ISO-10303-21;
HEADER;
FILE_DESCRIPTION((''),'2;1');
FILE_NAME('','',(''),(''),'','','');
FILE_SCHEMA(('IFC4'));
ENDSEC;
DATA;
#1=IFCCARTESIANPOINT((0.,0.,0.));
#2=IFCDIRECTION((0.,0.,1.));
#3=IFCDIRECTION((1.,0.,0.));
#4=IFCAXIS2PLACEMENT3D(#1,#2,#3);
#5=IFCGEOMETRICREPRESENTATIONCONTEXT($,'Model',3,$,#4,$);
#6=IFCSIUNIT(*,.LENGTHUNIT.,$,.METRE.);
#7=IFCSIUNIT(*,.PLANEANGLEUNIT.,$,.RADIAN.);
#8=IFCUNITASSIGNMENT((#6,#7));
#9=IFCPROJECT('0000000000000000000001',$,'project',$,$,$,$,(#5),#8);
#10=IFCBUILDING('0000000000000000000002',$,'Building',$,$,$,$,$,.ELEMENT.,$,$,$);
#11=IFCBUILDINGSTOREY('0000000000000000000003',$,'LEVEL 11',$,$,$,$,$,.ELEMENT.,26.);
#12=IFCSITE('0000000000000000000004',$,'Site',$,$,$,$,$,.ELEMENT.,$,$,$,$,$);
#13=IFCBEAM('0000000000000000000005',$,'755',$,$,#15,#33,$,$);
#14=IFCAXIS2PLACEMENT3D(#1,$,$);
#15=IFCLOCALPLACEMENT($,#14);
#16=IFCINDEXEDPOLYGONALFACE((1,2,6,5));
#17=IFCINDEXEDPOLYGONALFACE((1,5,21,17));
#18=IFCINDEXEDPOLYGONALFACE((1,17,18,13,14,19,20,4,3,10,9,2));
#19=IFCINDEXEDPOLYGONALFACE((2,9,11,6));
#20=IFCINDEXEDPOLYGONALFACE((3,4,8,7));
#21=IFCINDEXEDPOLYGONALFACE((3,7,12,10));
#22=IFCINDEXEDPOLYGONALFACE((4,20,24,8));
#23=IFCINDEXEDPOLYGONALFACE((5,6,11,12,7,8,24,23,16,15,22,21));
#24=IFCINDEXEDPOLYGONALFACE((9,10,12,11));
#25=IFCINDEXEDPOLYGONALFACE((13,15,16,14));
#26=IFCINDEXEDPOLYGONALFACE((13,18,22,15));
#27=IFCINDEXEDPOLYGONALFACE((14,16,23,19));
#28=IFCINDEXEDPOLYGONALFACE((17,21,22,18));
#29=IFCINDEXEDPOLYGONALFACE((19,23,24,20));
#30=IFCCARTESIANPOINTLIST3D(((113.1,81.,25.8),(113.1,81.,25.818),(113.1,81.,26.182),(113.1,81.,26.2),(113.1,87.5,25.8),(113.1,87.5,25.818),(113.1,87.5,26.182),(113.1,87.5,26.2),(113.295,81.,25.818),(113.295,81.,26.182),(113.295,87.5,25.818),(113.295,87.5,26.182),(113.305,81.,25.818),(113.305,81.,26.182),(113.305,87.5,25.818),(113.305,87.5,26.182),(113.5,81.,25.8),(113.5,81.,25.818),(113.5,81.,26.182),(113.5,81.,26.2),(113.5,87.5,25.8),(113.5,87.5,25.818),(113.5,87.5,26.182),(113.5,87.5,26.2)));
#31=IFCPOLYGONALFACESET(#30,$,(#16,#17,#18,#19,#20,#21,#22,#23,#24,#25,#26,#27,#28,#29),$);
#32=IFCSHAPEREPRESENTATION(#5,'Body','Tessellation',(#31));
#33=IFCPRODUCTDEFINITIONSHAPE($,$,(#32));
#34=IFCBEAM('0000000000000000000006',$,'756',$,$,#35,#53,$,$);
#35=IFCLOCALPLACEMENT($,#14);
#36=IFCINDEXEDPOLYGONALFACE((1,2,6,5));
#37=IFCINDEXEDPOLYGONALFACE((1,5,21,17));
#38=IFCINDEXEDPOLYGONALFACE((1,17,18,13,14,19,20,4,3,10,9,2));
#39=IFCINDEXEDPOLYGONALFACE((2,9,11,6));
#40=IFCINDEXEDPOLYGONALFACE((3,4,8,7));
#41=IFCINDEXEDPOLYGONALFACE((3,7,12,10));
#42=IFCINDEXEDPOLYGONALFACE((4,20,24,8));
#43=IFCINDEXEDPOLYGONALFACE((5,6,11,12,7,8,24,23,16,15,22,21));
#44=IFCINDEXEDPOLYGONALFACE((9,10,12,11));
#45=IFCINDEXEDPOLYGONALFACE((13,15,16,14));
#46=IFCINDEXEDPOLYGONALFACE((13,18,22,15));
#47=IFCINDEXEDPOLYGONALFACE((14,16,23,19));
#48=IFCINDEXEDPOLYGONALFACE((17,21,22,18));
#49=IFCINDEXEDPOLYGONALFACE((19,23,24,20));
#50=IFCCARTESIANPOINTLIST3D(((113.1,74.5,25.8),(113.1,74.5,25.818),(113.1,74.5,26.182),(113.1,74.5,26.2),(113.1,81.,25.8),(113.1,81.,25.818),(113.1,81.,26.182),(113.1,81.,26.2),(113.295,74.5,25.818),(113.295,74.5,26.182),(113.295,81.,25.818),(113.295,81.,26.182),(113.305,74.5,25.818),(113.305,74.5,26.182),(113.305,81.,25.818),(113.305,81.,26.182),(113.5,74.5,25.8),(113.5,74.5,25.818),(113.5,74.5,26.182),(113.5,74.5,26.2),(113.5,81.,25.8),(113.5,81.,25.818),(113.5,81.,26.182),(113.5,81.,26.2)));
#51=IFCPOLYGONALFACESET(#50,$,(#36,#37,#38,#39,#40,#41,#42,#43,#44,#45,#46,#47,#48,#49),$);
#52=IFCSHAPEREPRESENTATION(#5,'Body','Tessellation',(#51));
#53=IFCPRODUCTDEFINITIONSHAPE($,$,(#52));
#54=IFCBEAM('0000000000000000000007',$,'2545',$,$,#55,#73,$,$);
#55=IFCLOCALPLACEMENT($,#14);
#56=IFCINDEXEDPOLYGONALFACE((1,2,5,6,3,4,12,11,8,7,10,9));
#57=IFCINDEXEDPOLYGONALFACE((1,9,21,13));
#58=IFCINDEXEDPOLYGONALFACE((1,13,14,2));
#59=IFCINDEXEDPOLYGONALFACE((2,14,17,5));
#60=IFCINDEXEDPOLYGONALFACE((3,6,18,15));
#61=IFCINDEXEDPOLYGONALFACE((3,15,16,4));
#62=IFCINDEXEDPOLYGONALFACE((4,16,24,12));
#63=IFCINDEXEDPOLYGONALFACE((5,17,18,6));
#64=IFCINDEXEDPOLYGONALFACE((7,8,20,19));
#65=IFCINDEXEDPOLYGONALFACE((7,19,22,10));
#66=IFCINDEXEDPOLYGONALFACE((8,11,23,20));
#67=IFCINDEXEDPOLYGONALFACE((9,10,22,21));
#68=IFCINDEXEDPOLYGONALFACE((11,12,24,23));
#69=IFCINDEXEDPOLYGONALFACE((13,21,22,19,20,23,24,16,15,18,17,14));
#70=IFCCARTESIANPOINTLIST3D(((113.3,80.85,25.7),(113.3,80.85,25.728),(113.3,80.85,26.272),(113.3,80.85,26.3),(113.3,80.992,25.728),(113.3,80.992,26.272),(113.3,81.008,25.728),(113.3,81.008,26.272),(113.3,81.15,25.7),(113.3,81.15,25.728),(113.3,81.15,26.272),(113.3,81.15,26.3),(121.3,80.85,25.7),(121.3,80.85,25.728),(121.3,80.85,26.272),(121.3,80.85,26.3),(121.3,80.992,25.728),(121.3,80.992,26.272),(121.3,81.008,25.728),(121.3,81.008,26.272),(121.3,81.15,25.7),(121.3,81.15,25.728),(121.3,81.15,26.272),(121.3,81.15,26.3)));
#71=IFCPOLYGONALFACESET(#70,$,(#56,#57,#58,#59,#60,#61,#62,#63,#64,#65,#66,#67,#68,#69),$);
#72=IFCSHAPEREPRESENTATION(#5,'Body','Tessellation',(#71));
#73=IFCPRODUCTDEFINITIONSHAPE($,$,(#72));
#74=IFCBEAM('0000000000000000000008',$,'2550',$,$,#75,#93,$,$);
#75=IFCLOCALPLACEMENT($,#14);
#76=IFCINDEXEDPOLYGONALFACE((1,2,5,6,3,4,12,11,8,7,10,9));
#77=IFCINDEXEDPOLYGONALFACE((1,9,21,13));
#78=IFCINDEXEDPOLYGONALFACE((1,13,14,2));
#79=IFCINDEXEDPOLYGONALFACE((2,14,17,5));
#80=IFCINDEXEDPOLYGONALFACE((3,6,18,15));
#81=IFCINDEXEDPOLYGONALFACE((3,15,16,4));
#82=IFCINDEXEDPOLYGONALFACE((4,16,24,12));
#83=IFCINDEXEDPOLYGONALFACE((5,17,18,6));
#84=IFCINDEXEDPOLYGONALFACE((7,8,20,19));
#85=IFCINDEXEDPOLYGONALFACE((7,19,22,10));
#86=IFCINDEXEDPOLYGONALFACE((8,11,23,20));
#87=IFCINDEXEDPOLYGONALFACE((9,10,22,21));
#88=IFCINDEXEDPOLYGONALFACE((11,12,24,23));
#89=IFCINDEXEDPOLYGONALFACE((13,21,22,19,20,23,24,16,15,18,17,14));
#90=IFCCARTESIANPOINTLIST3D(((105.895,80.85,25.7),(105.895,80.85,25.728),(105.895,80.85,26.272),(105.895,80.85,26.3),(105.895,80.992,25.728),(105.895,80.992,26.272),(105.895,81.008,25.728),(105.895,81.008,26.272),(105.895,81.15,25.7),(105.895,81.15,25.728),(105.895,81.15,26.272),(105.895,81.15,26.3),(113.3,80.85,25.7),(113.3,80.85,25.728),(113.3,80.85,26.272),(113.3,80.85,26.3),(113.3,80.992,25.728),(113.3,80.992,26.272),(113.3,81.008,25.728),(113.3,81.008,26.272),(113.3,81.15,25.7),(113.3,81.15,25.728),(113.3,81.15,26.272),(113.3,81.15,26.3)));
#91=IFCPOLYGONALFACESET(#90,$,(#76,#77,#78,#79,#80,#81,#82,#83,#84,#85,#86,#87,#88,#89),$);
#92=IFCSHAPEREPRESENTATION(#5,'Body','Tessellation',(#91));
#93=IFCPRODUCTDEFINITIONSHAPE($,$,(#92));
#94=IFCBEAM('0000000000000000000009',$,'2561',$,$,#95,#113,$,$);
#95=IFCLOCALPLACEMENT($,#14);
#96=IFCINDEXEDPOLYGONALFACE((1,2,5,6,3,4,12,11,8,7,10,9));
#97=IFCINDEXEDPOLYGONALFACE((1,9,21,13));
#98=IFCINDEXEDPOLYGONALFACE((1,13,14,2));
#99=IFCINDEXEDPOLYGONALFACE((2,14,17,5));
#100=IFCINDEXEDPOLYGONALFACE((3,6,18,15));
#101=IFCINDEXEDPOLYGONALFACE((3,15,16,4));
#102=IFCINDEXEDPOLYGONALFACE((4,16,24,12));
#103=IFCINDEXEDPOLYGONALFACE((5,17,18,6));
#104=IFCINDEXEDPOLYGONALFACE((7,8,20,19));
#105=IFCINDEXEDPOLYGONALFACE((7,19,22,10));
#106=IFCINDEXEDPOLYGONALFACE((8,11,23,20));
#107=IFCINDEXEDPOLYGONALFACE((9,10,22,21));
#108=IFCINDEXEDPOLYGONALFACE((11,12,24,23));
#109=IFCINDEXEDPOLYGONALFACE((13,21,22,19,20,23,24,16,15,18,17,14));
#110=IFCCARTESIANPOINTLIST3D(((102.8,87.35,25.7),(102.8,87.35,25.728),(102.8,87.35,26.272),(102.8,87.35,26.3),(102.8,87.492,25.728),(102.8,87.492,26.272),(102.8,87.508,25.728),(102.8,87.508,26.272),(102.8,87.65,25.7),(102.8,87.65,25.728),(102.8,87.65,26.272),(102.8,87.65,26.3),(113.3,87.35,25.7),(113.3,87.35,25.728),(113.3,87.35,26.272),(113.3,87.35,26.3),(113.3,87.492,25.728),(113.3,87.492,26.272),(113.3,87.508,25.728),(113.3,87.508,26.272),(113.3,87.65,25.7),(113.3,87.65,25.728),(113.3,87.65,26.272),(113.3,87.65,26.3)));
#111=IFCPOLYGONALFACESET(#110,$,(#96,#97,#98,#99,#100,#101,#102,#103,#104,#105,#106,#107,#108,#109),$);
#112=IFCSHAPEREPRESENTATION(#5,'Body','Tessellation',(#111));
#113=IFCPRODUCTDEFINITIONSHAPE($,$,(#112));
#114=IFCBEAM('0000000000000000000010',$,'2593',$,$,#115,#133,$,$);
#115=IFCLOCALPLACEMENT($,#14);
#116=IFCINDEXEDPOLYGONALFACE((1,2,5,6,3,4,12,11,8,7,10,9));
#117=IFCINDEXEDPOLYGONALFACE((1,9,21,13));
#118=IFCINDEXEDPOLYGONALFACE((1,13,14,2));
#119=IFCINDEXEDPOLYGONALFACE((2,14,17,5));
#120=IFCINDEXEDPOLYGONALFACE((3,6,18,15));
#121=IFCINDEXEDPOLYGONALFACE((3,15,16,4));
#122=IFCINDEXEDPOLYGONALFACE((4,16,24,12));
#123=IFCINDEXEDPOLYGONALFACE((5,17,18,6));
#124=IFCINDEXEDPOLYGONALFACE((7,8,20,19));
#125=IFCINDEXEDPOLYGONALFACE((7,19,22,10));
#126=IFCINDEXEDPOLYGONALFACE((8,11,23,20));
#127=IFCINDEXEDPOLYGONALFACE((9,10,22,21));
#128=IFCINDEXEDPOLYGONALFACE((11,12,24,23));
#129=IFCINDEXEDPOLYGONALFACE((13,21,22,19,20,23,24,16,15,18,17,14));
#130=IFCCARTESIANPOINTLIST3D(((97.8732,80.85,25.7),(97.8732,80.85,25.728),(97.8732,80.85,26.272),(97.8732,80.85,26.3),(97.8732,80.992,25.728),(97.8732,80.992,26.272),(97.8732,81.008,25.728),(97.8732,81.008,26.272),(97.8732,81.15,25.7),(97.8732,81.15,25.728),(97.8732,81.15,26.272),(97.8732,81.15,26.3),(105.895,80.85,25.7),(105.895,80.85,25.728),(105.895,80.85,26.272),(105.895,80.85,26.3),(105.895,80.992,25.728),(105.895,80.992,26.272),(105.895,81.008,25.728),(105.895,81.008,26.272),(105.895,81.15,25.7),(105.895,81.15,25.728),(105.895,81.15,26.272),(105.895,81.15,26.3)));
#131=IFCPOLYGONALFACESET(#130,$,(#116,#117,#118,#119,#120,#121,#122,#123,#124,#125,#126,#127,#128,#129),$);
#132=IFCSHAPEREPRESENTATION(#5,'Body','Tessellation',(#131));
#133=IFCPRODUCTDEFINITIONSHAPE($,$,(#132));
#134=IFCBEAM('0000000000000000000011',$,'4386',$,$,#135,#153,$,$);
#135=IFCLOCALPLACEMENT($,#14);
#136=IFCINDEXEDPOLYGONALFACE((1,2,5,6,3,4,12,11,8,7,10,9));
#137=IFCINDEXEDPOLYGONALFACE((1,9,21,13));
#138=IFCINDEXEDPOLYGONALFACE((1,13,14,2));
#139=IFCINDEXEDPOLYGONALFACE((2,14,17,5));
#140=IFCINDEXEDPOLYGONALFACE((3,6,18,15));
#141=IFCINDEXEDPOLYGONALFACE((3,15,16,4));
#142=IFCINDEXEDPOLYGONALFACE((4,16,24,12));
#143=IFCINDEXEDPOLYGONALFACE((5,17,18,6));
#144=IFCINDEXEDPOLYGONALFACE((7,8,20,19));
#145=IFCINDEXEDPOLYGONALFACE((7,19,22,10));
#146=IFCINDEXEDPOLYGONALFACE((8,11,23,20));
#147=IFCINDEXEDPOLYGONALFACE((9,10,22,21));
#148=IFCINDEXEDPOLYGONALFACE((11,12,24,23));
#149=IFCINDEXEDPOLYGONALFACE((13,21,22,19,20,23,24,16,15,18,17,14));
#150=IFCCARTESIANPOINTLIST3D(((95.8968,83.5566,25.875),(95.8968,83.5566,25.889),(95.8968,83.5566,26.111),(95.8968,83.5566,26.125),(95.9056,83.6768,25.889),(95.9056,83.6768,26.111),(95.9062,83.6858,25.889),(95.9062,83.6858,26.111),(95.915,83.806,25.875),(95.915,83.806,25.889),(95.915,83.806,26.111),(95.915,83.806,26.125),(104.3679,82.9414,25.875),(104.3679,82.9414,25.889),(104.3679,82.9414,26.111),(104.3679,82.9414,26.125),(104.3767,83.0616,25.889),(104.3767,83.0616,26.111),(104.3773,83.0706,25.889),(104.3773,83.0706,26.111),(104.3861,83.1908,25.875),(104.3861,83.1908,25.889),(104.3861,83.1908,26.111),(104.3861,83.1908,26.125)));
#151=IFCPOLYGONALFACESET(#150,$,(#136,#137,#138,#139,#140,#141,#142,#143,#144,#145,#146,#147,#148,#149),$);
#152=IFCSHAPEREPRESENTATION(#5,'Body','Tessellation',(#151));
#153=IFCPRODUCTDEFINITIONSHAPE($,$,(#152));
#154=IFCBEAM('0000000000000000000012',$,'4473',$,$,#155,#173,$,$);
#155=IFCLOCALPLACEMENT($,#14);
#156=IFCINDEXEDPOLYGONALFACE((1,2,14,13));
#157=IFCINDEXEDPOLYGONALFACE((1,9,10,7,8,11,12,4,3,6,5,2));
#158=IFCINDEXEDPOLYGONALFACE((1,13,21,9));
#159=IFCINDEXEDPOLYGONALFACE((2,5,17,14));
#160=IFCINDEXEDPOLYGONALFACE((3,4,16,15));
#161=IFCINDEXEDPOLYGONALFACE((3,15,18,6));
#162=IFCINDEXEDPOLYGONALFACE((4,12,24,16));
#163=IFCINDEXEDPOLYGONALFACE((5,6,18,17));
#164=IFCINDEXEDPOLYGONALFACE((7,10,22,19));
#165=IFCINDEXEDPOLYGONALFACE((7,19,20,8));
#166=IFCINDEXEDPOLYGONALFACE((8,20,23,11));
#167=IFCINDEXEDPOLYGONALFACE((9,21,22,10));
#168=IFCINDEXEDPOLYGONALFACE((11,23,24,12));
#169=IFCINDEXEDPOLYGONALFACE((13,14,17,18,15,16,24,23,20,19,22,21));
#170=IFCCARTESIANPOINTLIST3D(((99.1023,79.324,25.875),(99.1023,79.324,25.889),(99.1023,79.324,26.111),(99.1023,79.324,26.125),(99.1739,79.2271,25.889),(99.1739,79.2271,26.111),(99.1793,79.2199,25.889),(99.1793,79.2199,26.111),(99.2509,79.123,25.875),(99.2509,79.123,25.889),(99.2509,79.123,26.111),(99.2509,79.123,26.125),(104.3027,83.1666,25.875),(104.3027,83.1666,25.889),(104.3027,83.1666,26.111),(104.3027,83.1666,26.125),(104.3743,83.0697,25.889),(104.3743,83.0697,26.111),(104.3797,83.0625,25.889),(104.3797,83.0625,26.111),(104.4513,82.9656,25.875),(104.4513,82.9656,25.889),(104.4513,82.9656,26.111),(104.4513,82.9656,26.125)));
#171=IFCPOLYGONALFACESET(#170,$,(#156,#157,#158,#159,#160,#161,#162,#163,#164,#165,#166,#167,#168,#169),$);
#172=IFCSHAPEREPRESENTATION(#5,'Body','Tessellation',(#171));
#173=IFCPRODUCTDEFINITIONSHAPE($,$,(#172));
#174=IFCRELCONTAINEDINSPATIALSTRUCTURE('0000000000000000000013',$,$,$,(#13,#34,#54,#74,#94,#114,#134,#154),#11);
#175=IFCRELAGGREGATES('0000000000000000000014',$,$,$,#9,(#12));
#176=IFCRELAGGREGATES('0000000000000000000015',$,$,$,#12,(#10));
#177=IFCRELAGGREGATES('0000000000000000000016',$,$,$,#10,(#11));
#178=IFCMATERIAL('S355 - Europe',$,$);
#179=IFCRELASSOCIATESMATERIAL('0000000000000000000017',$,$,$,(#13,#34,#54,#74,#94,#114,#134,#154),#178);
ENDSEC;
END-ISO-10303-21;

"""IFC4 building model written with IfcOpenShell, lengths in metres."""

from ifc_helpers import new_model, si_unit, frame, origin_with_axes, origin_2d_with_axis, place, context, project, spatial, i_section, extrude, material, material_profile, profile_set, profile_usage, element, save


model = new_model("IFC4")

# Units and contexts
model_context = context("Model", 3, world=origin_with_axes())
ifc_project = project(units=[si_unit("LENGTHUNIT", "METRE"), si_unit("PLANEANGLEUNIT", "RADIAN")], contexts=[model_context])

# Site, building, storey
site = spatial("IfcSite", under=ifc_project, Name="Site", CompositionType="ELEMENT")
building = spatial("IfcBuilding", under=site, Name="Building", CompositionType="ELEMENT")
storey = spatial("IfcBuildingStorey", under=building, Name="LEVEL 11", CompositionType="ELEMENT", Elevation=26.0)

# Shared definitions
ifc_material = material(Name="S355 - Europe")

# Beams
ifc_material_profile_1 = material_profile(ifc_material, i_section(OverallWidth=0.4, OverallDepth=0.4, WebThickness=0.01, FlangeThickness=0.018, at=origin_2d_with_axis()))
ifc_profile_set_1 = profile_set([ifc_material_profile_1])
ifc_profile_usage_1 = profile_usage(ifc_profile_set_1, cardinal=10)
beam_1_placement = place(None, frame((113.3, 81.0, 26.0), z_axis=(0.0, 1.0, 0.0), x_axis=(-1.0, 0.0, 0.0)))
element("IfcBeam", 1, at=beam_1_placement, inside=storey, material=ifc_profile_usage_1, Name="755", context=model_context, shape_type="SweptSolid", body=[
    extrude(i_section(OverallWidth=0.4, OverallDepth=0.4, WebThickness=0.01, FlangeThickness=0.018, at=origin_2d_with_axis()), origin_with_axes(), (0.0, 0.0, 1.0), 6.5),
])
ifc_material_profile_2 = material_profile(ifc_material, i_section(OverallWidth=0.4, OverallDepth=0.4, WebThickness=0.01, FlangeThickness=0.018, at=origin_2d_with_axis()))
ifc_profile_set_2 = profile_set([ifc_material_profile_2])
ifc_profile_usage_2 = profile_usage(ifc_profile_set_2, cardinal=10)
beam_2_placement = place(None, frame((113.3, 74.5, 26.0), z_axis=(0.0, 1.0, 0.0), x_axis=(-1.0, 0.0, 0.0)))
element("IfcBeam", 2, at=beam_2_placement, inside=storey, material=ifc_profile_usage_2, Name="756", context=model_context, shape_type="SweptSolid", body=[
    extrude(i_section(OverallWidth=0.4, OverallDepth=0.4, WebThickness=0.01, FlangeThickness=0.018, at=origin_2d_with_axis()), origin_with_axes(), (0.0, 0.0, 1.0), 6.5),
])
ifc_material_profile_3 = material_profile(ifc_material, i_section(OverallWidth=0.3, OverallDepth=0.6, WebThickness=0.016, FlangeThickness=0.028, at=origin_2d_with_axis()))
ifc_profile_set_3 = profile_set([ifc_material_profile_3])
ifc_profile_usage_3 = profile_usage(ifc_profile_set_3, cardinal=10)
beam_3_placement = place(None, frame((113.3, 81.0, 26.0), z_axis=(1.0, 0.0, 0.0), x_axis=(0.0, 1.0, 0.0)))
element("IfcBeam", 3, at=beam_3_placement, inside=storey, material=ifc_profile_usage_3, Name="2545", context=model_context, shape_type="SweptSolid", body=[
    extrude(i_section(OverallWidth=0.3, OverallDepth=0.6, WebThickness=0.016, FlangeThickness=0.028, at=origin_2d_with_axis()), origin_with_axes(), (0.0, 0.0, 1.0), 8.0),
])
ifc_material_profile_4 = material_profile(ifc_material, i_section(OverallWidth=0.3, OverallDepth=0.6, WebThickness=0.016, FlangeThickness=0.028, at=origin_2d_with_axis()))
ifc_profile_set_4 = profile_set([ifc_material_profile_4])
ifc_profile_usage_4 = profile_usage(ifc_profile_set_4, cardinal=10)
beam_4_placement = place(None, frame((113.3, 81.0, 26.0), z_axis=(-1.0, 0.0, 0.0), x_axis=(0.0, -1.0, 0.0)))
element("IfcBeam", 4, at=beam_4_placement, inside=storey, material=ifc_profile_usage_4, Name="2550", context=model_context, shape_type="SweptSolid", body=[
    extrude(i_section(OverallWidth=0.3, OverallDepth=0.6, WebThickness=0.016, FlangeThickness=0.028, at=origin_2d_with_axis()), origin_with_axes(), (0.0, 0.0, 1.0), 7.405),
])
ifc_material_profile_5 = material_profile(ifc_material, i_section(OverallWidth=0.3, OverallDepth=0.6, WebThickness=0.016, FlangeThickness=0.028, at=origin_2d_with_axis()))
ifc_profile_set_5 = profile_set([ifc_material_profile_5])
ifc_profile_usage_5 = profile_usage(ifc_profile_set_5, cardinal=10)
beam_5_placement = place(None, frame((102.8, 87.5, 26.0), z_axis=(1.0, 0.0, 0.0), x_axis=(0.0, 1.0, 0.0)))
element("IfcBeam", 5, at=beam_5_placement, inside=storey, material=ifc_profile_usage_5, Name="2561", context=model_context, shape_type="SweptSolid", body=[
    extrude(i_section(OverallWidth=0.3, OverallDepth=0.6, WebThickness=0.016, FlangeThickness=0.028, at=origin_2d_with_axis()), origin_with_axes(), (0.0, 0.0, 1.0), 10.5),
])
ifc_material_profile_6 = material_profile(ifc_material, i_section(OverallWidth=0.3, OverallDepth=0.6, WebThickness=0.016, FlangeThickness=0.028, at=origin_2d_with_axis()))
ifc_profile_set_6 = profile_set([ifc_material_profile_6])
ifc_profile_usage_6 = profile_usage(ifc_profile_set_6, cardinal=10)
beam_6_placement = place(None, frame((105.895, 81.0, 26.0), z_axis=(-1.0, 0.0, 0.0), x_axis=(0.0, -1.0, 0.0)))
element("IfcBeam", 6, at=beam_6_placement, inside=storey, material=ifc_profile_usage_6, Name="2593", context=model_context, shape_type="SweptSolid", body=[
    extrude(i_section(OverallWidth=0.3, OverallDepth=0.6, WebThickness=0.016, FlangeThickness=0.028, at=origin_2d_with_axis()), origin_with_axes(), (0.0, 0.0, 1.0), 8.0218),
])
ifc_material_profile_7 = material_profile(ifc_material, i_section(OverallWidth=0.25, OverallDepth=0.25, WebThickness=0.009, FlangeThickness=0.014, at=origin_2d_with_axis()))
ifc_profile_set_7 = profile_set([ifc_material_profile_7])
ifc_profile_usage_7 = profile_usage(ifc_profile_set_7, cardinal=10)
beam_7_placement = place(None, frame((104.377, 83.0661, 26.0), z_axis=(-0.997373, 0.072433, 0.0), x_axis=(-0.072433, -0.997373, 0.0)))
element("IfcBeam", 7, at=beam_7_placement, inside=storey, material=ifc_profile_usage_7, Name="4386", context=model_context, shape_type="SweptSolid", body=[
    extrude(i_section(OverallWidth=0.25, OverallDepth=0.25, WebThickness=0.009, FlangeThickness=0.014, at=origin_2d_with_axis()), origin_with_axes(), (0.0, 0.0, 1.0), 8.4934),
])
ifc_material_profile_8 = material_profile(ifc_material, i_section(OverallWidth=0.25, OverallDepth=0.25, WebThickness=0.009, FlangeThickness=0.014, at=origin_2d_with_axis()))
ifc_profile_set_8 = profile_set([ifc_material_profile_8])
ifc_profile_usage_8 = profile_usage(ifc_profile_set_8, cardinal=10)
beam_8_placement = place(None, frame((104.377, 83.0661, 26.0), z_axis=(-0.804263, -0.594274, 0.0), x_axis=(0.594274, -0.804263, 0.0)))
element("IfcBeam", 8, at=beam_8_placement, inside=storey, material=ifc_profile_usage_8, Name="4473", context=model_context, shape_type="SweptSolid", body=[
    extrude(i_section(OverallWidth=0.25, OverallDepth=0.25, WebThickness=0.009, FlangeThickness=0.014, at=origin_2d_with_axis()), origin_with_axes(), (0.0, 0.0, 1.0), 6.466),
])

save(model, "model.ifc")
